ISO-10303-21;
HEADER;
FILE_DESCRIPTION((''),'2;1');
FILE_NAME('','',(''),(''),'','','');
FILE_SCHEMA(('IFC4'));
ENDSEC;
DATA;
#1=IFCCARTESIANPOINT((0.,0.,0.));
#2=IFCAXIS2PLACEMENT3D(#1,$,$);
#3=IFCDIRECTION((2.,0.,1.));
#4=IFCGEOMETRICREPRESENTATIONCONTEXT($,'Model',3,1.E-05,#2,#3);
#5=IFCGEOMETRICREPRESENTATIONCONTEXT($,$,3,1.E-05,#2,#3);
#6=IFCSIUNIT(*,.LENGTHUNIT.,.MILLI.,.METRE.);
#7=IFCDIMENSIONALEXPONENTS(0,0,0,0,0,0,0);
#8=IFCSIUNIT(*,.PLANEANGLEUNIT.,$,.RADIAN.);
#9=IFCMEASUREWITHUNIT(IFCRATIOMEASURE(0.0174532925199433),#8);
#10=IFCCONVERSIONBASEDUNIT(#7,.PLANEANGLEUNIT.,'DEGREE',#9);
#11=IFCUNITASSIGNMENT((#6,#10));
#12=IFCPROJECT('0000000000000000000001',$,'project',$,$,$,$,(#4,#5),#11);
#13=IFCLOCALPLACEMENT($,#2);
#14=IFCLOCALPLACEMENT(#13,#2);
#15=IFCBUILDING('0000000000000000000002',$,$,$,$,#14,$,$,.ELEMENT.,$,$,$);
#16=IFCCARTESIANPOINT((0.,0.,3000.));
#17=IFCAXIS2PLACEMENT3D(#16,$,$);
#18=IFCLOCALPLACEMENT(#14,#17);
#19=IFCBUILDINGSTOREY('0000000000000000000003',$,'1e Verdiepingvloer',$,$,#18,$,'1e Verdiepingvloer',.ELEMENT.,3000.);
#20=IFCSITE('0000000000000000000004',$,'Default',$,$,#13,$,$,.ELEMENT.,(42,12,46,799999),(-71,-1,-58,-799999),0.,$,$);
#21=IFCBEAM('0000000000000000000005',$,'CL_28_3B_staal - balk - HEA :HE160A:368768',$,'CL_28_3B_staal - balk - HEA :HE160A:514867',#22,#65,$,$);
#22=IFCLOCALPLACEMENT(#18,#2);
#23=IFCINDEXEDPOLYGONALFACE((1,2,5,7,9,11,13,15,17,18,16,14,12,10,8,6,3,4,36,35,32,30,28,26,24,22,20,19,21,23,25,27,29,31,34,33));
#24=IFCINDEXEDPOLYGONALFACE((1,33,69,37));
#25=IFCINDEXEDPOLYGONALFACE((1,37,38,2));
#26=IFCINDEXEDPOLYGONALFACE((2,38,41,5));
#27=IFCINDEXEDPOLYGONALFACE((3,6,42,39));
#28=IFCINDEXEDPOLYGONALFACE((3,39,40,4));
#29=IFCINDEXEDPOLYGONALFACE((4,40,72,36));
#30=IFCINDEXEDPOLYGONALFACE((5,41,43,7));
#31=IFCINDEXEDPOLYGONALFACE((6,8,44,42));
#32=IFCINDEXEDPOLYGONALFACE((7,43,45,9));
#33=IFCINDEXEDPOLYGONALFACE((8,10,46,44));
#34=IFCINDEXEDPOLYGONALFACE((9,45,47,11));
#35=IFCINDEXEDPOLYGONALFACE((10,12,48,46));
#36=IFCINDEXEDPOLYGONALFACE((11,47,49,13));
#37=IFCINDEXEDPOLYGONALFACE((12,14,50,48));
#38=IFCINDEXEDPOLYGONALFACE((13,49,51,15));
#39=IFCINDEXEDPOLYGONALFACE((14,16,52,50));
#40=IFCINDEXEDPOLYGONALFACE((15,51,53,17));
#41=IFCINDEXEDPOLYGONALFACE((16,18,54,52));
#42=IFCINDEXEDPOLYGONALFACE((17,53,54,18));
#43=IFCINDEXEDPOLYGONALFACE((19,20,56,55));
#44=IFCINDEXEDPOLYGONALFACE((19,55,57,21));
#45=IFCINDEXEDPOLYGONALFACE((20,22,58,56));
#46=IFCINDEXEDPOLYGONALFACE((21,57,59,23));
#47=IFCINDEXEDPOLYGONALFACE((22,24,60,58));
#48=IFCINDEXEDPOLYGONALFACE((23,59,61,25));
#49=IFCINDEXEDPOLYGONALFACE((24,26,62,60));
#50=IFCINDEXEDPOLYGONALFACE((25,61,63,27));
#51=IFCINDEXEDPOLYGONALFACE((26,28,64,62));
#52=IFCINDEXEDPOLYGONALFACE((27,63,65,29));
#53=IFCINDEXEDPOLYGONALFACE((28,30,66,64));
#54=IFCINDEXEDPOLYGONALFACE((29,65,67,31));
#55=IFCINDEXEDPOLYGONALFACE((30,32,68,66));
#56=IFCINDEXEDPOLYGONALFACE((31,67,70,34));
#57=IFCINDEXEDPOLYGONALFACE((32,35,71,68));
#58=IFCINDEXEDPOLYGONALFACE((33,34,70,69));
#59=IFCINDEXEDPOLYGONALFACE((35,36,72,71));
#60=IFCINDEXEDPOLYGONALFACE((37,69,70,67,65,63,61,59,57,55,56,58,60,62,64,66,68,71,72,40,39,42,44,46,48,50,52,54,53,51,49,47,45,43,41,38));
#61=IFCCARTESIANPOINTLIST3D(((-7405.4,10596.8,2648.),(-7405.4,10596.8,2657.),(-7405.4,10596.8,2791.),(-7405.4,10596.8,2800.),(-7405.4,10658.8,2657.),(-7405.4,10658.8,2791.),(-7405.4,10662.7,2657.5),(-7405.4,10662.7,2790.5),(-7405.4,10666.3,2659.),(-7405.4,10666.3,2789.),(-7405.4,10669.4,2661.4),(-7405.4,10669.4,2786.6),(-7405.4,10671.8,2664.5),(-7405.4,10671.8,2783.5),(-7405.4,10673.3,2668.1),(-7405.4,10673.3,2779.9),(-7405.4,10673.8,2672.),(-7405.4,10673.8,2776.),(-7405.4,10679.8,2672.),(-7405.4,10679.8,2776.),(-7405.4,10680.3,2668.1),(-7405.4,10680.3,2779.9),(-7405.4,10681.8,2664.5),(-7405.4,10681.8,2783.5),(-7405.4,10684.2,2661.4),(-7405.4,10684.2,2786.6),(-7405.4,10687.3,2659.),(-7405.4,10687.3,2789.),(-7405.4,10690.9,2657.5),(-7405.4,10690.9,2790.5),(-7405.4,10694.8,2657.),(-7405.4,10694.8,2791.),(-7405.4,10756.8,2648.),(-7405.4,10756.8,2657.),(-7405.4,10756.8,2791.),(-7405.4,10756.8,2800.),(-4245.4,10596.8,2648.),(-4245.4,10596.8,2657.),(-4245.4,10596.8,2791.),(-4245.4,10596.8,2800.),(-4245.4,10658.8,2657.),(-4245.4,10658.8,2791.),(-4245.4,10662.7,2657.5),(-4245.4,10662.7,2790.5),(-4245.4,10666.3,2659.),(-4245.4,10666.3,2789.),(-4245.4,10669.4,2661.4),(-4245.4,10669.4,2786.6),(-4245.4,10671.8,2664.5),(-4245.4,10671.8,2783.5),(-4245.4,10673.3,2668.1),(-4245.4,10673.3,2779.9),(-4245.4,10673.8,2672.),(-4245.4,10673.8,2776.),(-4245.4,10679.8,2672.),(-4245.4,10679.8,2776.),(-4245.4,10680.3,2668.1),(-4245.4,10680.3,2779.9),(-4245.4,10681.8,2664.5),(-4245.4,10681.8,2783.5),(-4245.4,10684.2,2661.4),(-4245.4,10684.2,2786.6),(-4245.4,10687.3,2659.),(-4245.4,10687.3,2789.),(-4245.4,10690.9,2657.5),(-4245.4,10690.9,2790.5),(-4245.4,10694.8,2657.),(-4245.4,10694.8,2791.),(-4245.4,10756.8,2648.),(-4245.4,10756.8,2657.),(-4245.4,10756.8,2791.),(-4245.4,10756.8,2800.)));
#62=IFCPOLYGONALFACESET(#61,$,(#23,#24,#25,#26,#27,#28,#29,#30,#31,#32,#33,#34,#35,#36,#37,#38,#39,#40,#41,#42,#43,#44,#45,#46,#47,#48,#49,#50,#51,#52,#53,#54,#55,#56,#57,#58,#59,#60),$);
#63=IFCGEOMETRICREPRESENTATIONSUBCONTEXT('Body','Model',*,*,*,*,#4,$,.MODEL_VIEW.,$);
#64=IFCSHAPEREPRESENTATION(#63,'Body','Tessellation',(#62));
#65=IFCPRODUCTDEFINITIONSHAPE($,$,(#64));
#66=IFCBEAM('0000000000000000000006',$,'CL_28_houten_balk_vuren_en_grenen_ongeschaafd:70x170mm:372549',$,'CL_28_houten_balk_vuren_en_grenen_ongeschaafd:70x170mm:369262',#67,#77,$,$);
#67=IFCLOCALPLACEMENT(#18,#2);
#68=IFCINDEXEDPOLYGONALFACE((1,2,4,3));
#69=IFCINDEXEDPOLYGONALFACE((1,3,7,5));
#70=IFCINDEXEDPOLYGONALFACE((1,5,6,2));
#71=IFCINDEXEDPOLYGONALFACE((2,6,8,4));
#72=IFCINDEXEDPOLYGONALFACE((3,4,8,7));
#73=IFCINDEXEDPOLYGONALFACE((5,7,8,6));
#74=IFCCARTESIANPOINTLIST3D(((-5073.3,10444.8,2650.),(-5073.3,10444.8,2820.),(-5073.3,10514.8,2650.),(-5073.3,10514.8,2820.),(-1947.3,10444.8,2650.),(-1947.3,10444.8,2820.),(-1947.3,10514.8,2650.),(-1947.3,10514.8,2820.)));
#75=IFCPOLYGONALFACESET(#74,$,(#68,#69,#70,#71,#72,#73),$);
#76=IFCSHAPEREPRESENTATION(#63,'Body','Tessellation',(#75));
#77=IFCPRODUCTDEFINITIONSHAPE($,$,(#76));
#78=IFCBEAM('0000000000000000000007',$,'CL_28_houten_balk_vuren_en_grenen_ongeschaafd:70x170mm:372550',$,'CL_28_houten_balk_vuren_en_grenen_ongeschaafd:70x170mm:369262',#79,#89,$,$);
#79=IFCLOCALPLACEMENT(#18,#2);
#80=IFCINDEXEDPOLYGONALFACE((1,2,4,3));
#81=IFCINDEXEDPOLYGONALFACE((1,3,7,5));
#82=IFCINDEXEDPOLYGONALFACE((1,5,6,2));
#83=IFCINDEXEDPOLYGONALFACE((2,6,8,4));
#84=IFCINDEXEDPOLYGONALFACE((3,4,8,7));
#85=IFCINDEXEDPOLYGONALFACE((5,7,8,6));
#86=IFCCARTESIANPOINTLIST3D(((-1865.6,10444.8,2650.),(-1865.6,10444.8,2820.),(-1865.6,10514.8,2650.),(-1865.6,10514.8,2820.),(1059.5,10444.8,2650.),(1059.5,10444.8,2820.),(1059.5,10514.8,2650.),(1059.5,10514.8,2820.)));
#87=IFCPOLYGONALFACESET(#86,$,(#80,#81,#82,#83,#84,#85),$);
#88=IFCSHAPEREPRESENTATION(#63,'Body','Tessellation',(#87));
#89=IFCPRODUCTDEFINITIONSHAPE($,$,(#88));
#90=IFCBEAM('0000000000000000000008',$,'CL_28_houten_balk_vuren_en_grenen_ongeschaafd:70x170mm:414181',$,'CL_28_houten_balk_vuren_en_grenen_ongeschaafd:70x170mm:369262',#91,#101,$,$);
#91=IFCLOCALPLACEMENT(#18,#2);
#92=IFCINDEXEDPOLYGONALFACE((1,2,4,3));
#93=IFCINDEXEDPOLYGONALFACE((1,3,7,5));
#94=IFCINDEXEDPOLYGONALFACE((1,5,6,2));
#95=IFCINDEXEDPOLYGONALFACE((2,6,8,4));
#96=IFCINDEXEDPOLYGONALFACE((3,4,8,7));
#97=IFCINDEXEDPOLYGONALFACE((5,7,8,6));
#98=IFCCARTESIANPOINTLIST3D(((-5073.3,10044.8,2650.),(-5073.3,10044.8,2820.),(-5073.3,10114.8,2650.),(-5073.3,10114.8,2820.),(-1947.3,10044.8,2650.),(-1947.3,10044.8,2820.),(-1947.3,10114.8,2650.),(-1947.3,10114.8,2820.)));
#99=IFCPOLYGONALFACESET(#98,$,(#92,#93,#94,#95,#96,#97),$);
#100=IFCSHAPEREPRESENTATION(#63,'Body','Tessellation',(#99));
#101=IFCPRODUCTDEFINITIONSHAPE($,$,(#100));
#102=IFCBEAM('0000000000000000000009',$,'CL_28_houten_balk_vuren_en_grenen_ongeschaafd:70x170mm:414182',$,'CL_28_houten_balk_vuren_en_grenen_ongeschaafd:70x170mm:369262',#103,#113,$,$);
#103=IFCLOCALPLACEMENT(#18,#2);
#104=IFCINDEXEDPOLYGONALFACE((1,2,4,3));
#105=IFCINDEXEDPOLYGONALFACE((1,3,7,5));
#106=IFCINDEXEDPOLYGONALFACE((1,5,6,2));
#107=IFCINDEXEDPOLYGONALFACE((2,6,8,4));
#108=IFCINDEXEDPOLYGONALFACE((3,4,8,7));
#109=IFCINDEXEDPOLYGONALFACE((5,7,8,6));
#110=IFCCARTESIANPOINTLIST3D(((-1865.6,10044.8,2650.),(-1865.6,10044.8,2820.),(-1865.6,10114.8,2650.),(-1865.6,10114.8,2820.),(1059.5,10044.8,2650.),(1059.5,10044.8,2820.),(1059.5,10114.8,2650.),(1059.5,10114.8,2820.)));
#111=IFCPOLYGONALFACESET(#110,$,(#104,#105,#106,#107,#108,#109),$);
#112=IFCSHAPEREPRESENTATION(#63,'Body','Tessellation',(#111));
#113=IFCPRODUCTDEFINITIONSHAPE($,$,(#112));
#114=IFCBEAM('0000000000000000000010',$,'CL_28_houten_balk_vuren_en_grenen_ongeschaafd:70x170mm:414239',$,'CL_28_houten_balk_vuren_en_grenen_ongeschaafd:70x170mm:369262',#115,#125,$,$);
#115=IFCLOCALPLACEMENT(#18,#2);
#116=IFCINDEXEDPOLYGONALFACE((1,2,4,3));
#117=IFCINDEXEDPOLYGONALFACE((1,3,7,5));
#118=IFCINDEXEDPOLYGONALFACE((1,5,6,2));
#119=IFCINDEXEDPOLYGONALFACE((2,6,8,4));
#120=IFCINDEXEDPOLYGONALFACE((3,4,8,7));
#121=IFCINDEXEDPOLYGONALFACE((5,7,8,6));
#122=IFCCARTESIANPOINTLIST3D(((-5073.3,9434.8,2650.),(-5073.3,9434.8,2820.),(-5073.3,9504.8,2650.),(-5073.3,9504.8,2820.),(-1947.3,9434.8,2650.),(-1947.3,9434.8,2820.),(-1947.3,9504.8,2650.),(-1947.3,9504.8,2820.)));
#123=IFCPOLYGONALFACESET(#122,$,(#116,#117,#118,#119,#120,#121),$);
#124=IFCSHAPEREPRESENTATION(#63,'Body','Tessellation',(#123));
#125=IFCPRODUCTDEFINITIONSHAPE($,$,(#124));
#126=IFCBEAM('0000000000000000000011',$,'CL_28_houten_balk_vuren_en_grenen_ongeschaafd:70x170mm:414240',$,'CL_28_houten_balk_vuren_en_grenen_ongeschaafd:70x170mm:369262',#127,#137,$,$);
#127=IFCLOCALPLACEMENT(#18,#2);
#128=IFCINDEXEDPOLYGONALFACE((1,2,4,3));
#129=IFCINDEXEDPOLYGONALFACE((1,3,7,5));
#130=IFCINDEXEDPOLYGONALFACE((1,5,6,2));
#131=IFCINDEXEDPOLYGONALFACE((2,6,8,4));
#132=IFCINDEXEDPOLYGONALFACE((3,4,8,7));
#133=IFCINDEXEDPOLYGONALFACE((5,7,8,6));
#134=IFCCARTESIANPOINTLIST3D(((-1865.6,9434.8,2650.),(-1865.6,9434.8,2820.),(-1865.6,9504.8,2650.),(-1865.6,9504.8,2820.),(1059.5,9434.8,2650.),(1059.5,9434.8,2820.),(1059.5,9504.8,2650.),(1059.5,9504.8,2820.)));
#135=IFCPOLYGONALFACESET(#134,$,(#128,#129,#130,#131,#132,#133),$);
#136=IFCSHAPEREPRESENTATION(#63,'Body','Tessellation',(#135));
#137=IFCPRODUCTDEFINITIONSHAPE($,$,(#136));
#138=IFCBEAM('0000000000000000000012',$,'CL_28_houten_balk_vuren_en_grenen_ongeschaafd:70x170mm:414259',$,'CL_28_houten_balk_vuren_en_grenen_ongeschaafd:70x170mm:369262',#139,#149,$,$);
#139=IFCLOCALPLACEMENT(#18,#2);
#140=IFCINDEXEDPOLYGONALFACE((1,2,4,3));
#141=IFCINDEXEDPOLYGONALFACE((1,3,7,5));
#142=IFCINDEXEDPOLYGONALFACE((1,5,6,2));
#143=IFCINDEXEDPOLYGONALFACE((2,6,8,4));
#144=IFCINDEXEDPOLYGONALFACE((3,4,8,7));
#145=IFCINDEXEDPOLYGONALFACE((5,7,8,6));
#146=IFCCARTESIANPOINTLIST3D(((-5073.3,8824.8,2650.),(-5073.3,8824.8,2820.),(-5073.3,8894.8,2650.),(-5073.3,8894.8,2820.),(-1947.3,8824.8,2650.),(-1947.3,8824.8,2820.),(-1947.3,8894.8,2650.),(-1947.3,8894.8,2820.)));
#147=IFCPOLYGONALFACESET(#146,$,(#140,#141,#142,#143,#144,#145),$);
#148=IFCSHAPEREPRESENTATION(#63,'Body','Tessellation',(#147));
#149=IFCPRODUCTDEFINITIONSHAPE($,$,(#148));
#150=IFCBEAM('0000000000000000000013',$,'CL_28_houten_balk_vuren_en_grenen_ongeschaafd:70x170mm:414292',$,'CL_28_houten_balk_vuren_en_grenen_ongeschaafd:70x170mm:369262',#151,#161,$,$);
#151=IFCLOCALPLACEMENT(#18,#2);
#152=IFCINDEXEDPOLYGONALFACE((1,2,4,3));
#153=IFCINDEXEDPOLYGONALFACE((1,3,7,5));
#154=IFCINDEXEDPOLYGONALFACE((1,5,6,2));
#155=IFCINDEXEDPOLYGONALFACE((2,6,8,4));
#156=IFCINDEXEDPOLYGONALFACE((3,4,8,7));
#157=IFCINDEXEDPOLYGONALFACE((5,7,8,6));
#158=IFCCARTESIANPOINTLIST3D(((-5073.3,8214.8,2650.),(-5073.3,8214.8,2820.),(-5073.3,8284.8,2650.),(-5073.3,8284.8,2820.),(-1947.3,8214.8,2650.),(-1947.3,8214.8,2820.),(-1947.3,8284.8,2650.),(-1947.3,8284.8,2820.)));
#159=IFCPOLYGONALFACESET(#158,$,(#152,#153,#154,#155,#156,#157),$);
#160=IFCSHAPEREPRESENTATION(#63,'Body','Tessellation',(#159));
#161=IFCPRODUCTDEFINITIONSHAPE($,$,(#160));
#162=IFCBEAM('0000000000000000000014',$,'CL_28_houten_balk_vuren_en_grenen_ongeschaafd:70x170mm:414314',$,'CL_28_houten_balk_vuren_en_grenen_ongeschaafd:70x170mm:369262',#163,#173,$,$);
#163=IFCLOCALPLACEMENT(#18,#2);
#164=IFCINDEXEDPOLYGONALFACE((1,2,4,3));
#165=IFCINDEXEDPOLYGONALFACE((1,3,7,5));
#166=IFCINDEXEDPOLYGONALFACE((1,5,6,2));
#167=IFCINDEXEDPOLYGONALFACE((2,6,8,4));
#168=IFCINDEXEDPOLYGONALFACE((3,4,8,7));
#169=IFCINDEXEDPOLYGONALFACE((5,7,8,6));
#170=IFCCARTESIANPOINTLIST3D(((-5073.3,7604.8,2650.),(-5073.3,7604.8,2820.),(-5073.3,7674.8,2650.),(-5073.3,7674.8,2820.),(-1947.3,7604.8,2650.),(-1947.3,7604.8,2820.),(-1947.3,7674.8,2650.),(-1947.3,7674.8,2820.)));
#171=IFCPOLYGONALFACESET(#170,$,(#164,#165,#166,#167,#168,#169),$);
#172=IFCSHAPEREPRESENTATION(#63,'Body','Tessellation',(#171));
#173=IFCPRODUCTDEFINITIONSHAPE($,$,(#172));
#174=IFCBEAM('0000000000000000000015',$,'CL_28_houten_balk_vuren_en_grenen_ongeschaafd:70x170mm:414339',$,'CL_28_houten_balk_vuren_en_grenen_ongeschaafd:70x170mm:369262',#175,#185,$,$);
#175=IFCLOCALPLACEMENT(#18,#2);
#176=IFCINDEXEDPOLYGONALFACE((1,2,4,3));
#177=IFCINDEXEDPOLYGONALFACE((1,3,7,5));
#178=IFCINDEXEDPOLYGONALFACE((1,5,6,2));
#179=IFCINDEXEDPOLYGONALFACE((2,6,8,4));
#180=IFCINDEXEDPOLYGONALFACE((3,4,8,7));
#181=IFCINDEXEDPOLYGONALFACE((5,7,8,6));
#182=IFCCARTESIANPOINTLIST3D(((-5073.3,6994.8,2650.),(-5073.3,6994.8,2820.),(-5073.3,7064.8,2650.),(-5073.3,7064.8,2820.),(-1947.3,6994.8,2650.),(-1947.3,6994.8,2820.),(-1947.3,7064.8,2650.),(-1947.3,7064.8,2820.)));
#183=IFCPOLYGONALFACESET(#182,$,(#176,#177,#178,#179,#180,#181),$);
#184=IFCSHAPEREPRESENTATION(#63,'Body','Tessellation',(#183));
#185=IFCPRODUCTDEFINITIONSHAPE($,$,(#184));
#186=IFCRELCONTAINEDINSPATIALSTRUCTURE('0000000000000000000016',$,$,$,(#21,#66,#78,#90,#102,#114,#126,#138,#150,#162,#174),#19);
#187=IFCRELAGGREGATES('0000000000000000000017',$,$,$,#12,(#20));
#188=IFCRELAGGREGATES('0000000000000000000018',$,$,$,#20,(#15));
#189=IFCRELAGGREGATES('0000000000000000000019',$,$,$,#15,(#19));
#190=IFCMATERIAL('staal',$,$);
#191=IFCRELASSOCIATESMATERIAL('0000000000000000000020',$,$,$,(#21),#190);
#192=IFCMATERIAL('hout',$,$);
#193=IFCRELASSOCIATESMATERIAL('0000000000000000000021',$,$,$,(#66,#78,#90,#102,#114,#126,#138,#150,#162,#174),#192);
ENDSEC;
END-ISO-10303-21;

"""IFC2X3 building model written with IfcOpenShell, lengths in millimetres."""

from ifc_helpers import new_model, entity, si_unit, converted_unit, direction, frame, frame_2d, origin, place, context, subcontext, project, spatial, rectangle, i_section, extrude, material, element, save


model = new_model("IFC2X3")

# Units and contexts
model_context = context("Model", 3, precision=1e-05, world=origin(), true_north=direction((2.0, 0.0, 1.0)))
context_of_model = context(None, 3, precision=1e-05, world=origin(), true_north=direction((2.0, 0.0, 1.0)))
body_context = subcontext(model_context, "Body", "Model", "MODEL_VIEW")
ifc_project = project(units=[si_unit("LENGTHUNIT", "METRE", prefix="MILLI"), converted_unit("PLANEANGLEUNIT", "DEGREE", entity("IfcRatioMeasure", 0.0174532925199433), si_unit("PLANEANGLEUNIT", "RADIAN"), dimensions=[0, 0, 0, 0, 0, 0, 0])], contexts=[model_context, context_of_model])

# Site, building, storey
site_placement = place(None, origin())
site = spatial("IfcSite", under=ifc_project, at=site_placement, Name="Default", CompositionType="ELEMENT", RefLatitude=(42, 12, 46, 799999), RefLongitude=(-71, -1, -58, -799999), RefElevation=0.0)
building_placement = place(site_placement, origin())
building = spatial("IfcBuilding", under=site, at=building_placement, CompositionType="ELEMENT")
storey_placement = place(building_placement, frame((0.0, 0.0, 3000.0)))
storey = spatial("IfcBuildingStorey", under=building, at=storey_placement, Name="1e Verdiepingvloer", LongName="1e Verdiepingvloer", CompositionType="ELEMENT", Elevation=3000.0)

# Beams
ifc_material_1 = material(Name="staal")
beam_1_placement = place(storey_placement, frame((-7252.9, 10676.8, 2800.0)))
element("IfcBeam", 1, at=beam_1_placement, inside=storey, material=ifc_material_1, Name="CL_28_3B_staal - balk - HEA :HE160A:368768", ObjectType="CL_28_3B_staal - balk - HEA :HE160A:514867", context=body_context, shape_type="SweptSolid", body=[
    extrude(i_section(OverallWidth=160.0, OverallDepth=152.0, WebThickness=6.0, FlangeThickness=9.0, FilletRadius=15.0, at=frame_2d((0.0, 0.0), x_axis=(0.0, 1.0))), frame((-152.5, 0.0, -76.0), z_axis=(1.0, 0.0, 0.0), x_axis=(0.0, 0.0, -1.0)), (0.0, 0.0, 1.0), 3160.0),
])
ifc_material_2 = material(Name="hout")
beam_2_placement = place(storey_placement, frame((-5228.9, 10479.8, 2820.0)))
element("IfcBeam", 2, at=beam_2_placement, inside=storey, material=ifc_material_2, Name="CL_28_houten_balk_vuren_en_grenen_ongeschaafd:70x170mm:372549", ObjectType="CL_28_houten_balk_vuren_en_grenen_ongeschaafd:70x170mm:369262", context=body_context, shape_type="SweptSolid", body=[
    extrude(rectangle(XDim=170.0, YDim=70.0, at=frame_2d((0.0, 0.0), x_axis=(1.0, 0.0))), frame((155.6, 0.0, -85.0), z_axis=(1.0, 0.0, 0.0), x_axis=(0.0, 0.0, -1.0)), (0.0, 0.0, 1.0), 3126.0),
])
beam_3_placement = place(storey_placement, frame((-2128.9, 10479.8, 2820.0)))
element("IfcBeam", 3, at=beam_3_placement, inside=storey, material=ifc_material_2, Name="CL_28_houten_balk_vuren_en_grenen_ongeschaafd:70x170mm:372550", ObjectType="CL_28_houten_balk_vuren_en_grenen_ongeschaafd:70x170mm:369262", context=body_context, shape_type="SweptSolid", body=[
    extrude(rectangle(XDim=170.0, YDim=70.0, at=frame_2d((0.0, 0.0), x_axis=(1.0, 0.0))), frame((263.4, 0.0, -85.0), z_axis=(1.0, 0.0, 0.0), x_axis=(0.0, 0.0, -1.0)), (0.0, 0.0, 1.0), 2925.0),
])
beam_4_placement = place(storey_placement, frame((-5228.9, 10079.8, 2820.0)))
element("IfcBeam", 4, at=beam_4_placement, inside=storey, material=ifc_material_2, Name="CL_28_houten_balk_vuren_en_grenen_ongeschaafd:70x170mm:414181", ObjectType="CL_28_houten_balk_vuren_en_grenen_ongeschaafd:70x170mm:369262", context=body_context, shape_type="SweptSolid", body=[
    extrude(rectangle(XDim=170.0, YDim=70.0, at=frame_2d((0.0, 0.0), x_axis=(1.0, 0.0))), frame((155.6, 0.0, -85.0), z_axis=(1.0, 0.0, 0.0), x_axis=(0.0, 0.0, -1.0)), (0.0, 0.0, 1.0), 3126.0),
])
beam_5_placement = place(storey_placement, frame((-2128.9, 10079.8, 2820.0)))
element("IfcBeam", 5, at=beam_5_placement, inside=storey, material=ifc_material_2, Name="CL_28_houten_balk_vuren_en_grenen_ongeschaafd:70x170mm:414182", ObjectType="CL_28_houten_balk_vuren_en_grenen_ongeschaafd:70x170mm:369262", context=body_context, shape_type="SweptSolid", body=[
    extrude(rectangle(XDim=170.0, YDim=70.0, at=frame_2d((0.0, 0.0), x_axis=(1.0, 0.0))), frame((263.4, 0.0, -85.0), z_axis=(1.0, 0.0, 0.0), x_axis=(0.0, 0.0, -1.0)), (0.0, 0.0, 1.0), 2925.0),
])
beam_6_placement = place(storey_placement, frame((-5228.9, 9469.8, 2820.0)))
element("IfcBeam", 6, at=beam_6_placement, inside=storey, material=ifc_material_2, Name="CL_28_houten_balk_vuren_en_grenen_ongeschaafd:70x170mm:414239", ObjectType="CL_28_houten_balk_vuren_en_grenen_ongeschaafd:70x170mm:369262", context=body_context, shape_type="SweptSolid", body=[
    extrude(rectangle(XDim=170.0, YDim=70.0, at=frame_2d((0.0, 0.0), x_axis=(1.0, 0.0))), frame((155.6, 0.0, -85.0), z_axis=(1.0, 0.0, 0.0), x_axis=(0.0, 0.0, -1.0)), (0.0, 0.0, 1.0), 3126.0),
])
beam_7_placement = place(storey_placement, frame((-2128.9, 9469.8, 2820.0)))
element("IfcBeam", 7, at=beam_7_placement, inside=storey, material=ifc_material_2, Name="CL_28_houten_balk_vuren_en_grenen_ongeschaafd:70x170mm:414240", ObjectType="CL_28_houten_balk_vuren_en_grenen_ongeschaafd:70x170mm:369262", context=body_context, shape_type="SweptSolid", body=[
    extrude(rectangle(XDim=170.0, YDim=70.0, at=frame_2d((0.0, 0.0), x_axis=(1.0, 0.0))), frame((263.4, 0.0, -85.0), z_axis=(1.0, 0.0, 0.0), x_axis=(0.0, 0.0, -1.0)), (0.0, 0.0, 1.0), 2925.0),
])
beam_8_placement = place(storey_placement, frame((-5228.9, 8859.8, 2820.0)))
element("IfcBeam", 8, at=beam_8_placement, inside=storey, material=ifc_material_2, Name="CL_28_houten_balk_vuren_en_grenen_ongeschaafd:70x170mm:414259", ObjectType="CL_28_houten_balk_vuren_en_grenen_ongeschaafd:70x170mm:369262", context=body_context, shape_type="SweptSolid", body=[
    extrude(rectangle(XDim=170.0, YDim=70.0, at=frame_2d((0.0, 0.0), x_axis=(1.0, 0.0))), frame((155.6, 0.0, -85.0), z_axis=(1.0, 0.0, 0.0), x_axis=(0.0, 0.0, -1.0)), (0.0, 0.0, 1.0), 3126.0),
])
beam_9_placement = place(storey_placement, frame((-5228.9, 8249.8, 2820.0)))
element("IfcBeam", 9, at=beam_9_placement, inside=storey, material=ifc_material_2, Name="CL_28_houten_balk_vuren_en_grenen_ongeschaafd:70x170mm:414292", ObjectType="CL_28_houten_balk_vuren_en_grenen_ongeschaafd:70x170mm:369262", context=body_context, shape_type="SweptSolid", body=[
    extrude(rectangle(XDim=170.0, YDim=70.0, at=frame_2d((0.0, 0.0), x_axis=(1.0, 0.0))), frame((155.6, 0.0, -85.0), z_axis=(1.0, 0.0, 0.0), x_axis=(0.0, 0.0, -1.0)), (0.0, 0.0, 1.0), 3126.0),
])
beam_10_placement = place(storey_placement, frame((-5228.9, 7639.8, 2820.0)))
element("IfcBeam", 10, at=beam_10_placement, inside=storey, material=ifc_material_2, Name="CL_28_houten_balk_vuren_en_grenen_ongeschaafd:70x170mm:414314", ObjectType="CL_28_houten_balk_vuren_en_grenen_ongeschaafd:70x170mm:369262", context=body_context, shape_type="SweptSolid", body=[
    extrude(rectangle(XDim=170.0, YDim=70.0, at=frame_2d((0.0, 0.0), x_axis=(1.0, 0.0))), frame((155.6, 0.0, -85.0), z_axis=(1.0, 0.0, 0.0), x_axis=(0.0, 0.0, -1.0)), (0.0, 0.0, 1.0), 3126.0),
])
beam_11_placement = place(storey_placement, frame((-5228.9, 7029.8, 2820.0)))
element("IfcBeam", 11, at=beam_11_placement, inside=storey, material=ifc_material_2, Name="CL_28_houten_balk_vuren_en_grenen_ongeschaafd:70x170mm:414339", ObjectType="CL_28_houten_balk_vuren_en_grenen_ongeschaafd:70x170mm:369262", context=body_context, shape_type="SweptSolid", body=[
    extrude(rectangle(XDim=170.0, YDim=70.0, at=frame_2d((0.0, 0.0), x_axis=(1.0, 0.0))), frame((155.6, 0.0, -85.0), z_axis=(1.0, 0.0, 0.0), x_axis=(0.0, 0.0, -1.0)), (0.0, 0.0, 1.0), 3126.0),
])

save(model, "model.ifc")
